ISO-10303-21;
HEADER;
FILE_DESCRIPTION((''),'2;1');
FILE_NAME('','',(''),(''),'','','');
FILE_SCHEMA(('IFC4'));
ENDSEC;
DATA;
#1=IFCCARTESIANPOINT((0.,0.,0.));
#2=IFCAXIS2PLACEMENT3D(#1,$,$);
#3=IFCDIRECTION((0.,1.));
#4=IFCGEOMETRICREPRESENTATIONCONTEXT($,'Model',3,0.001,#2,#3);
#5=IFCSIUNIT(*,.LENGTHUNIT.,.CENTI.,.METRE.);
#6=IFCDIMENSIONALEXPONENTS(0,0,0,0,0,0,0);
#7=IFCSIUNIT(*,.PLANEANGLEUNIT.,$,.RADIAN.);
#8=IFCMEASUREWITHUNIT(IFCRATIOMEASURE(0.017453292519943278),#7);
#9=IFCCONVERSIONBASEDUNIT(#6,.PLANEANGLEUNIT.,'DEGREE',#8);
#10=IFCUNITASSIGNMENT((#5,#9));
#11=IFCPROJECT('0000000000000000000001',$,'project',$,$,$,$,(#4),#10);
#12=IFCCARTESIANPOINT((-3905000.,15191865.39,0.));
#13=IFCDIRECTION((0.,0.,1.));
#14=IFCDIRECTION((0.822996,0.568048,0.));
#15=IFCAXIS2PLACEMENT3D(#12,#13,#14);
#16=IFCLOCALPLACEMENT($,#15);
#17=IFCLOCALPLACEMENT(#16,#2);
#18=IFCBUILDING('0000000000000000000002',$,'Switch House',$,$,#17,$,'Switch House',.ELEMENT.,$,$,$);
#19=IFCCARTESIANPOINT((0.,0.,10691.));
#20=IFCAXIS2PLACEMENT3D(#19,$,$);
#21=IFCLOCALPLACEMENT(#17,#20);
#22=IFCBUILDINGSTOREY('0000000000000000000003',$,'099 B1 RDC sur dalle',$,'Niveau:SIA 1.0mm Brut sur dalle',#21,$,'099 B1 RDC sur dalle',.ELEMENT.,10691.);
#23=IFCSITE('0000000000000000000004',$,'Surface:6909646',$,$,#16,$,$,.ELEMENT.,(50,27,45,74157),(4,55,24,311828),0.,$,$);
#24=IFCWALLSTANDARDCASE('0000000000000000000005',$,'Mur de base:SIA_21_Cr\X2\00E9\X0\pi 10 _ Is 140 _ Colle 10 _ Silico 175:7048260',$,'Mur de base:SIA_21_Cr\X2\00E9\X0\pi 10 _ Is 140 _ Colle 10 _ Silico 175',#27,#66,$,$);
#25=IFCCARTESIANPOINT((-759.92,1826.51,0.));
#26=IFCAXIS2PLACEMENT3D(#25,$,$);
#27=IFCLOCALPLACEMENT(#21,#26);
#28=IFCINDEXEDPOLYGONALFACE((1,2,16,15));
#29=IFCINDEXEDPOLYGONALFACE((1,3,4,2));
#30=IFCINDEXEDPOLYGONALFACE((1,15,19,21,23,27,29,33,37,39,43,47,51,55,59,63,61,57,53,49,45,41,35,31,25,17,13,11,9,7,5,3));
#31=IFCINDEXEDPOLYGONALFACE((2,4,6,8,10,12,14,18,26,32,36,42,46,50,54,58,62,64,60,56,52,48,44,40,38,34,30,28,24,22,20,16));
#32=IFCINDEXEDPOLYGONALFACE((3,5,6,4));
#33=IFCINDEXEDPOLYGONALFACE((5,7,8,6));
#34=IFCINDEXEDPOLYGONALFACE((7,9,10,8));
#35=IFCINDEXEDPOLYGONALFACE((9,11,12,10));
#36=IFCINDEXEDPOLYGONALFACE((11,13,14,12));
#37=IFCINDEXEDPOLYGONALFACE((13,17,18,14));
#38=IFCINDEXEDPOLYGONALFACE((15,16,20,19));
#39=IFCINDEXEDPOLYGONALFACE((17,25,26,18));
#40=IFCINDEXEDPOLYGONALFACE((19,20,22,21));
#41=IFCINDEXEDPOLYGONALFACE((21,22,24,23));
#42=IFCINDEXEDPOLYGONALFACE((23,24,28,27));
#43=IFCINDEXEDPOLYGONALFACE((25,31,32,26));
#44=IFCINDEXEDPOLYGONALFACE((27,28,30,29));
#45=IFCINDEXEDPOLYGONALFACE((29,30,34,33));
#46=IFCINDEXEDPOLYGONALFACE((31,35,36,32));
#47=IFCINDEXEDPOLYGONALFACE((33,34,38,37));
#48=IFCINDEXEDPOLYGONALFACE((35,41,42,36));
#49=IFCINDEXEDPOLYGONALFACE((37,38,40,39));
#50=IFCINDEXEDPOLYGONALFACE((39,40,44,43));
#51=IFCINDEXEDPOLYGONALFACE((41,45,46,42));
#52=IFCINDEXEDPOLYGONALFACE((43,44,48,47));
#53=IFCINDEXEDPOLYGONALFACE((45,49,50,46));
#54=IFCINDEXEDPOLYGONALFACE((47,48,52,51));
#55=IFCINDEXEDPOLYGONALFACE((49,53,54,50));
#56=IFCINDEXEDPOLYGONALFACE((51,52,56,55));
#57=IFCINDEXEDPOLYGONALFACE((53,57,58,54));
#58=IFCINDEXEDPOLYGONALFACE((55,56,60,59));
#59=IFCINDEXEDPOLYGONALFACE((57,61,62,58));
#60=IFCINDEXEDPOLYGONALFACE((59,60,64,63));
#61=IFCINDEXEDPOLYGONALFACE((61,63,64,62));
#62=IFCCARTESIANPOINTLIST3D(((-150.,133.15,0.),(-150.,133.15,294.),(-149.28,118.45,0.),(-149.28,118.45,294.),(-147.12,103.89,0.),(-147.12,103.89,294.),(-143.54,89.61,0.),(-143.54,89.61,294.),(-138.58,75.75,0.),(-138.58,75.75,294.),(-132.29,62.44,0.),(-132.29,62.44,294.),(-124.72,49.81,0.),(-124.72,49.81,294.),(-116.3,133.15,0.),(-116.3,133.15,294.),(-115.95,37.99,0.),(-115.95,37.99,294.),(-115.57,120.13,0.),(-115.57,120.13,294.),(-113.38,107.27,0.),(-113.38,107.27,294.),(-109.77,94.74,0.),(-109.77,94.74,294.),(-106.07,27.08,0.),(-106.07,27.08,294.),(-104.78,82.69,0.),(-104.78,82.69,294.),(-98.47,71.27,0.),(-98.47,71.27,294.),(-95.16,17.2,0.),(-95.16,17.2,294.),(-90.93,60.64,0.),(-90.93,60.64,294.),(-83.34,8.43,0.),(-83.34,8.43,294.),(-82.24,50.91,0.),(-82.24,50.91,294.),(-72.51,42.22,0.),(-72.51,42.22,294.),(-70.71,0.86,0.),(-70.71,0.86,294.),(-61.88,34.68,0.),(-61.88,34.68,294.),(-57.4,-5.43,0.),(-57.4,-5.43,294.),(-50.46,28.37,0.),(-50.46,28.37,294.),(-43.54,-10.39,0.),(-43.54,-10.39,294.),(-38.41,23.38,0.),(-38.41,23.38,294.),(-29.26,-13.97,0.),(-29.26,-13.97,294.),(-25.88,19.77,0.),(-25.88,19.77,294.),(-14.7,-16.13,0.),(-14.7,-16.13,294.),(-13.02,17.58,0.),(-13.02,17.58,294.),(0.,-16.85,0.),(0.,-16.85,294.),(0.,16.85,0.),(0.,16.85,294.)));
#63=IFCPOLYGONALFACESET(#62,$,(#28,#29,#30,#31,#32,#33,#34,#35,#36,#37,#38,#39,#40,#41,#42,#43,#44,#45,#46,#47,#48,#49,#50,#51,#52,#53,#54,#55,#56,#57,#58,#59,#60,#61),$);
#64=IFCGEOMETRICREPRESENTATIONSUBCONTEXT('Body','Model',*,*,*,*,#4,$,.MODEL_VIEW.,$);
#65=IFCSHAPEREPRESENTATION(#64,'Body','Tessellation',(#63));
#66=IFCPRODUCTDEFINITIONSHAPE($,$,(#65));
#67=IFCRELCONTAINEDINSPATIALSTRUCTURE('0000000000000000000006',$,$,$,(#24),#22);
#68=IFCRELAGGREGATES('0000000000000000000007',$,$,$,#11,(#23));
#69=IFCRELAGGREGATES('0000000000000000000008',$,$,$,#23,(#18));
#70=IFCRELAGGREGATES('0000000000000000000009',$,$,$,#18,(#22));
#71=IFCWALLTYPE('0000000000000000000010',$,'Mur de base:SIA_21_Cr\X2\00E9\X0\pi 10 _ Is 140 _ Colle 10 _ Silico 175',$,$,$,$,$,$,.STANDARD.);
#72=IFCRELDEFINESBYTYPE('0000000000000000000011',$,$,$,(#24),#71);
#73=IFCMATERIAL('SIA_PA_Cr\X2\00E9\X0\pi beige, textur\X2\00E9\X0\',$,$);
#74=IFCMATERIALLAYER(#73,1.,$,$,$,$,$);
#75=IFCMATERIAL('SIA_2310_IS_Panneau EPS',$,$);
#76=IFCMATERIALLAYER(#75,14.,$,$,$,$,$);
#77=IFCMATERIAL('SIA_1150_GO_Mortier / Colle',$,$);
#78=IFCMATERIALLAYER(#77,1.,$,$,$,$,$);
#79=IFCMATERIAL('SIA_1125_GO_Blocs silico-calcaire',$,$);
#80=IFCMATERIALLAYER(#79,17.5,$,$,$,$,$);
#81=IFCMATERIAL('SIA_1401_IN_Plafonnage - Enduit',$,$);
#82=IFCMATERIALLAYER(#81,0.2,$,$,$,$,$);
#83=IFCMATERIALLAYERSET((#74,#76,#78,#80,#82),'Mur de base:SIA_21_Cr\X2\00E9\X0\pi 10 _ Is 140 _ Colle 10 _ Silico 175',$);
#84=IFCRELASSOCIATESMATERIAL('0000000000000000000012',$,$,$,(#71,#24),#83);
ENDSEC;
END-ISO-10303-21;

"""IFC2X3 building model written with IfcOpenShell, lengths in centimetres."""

from ifc_helpers import new_model, entity, si_unit, converted_unit, direction, frame, frame_2d, origin, place, context, subcontext, project, spatial, polyline, circle_curve, parameter, trimmed, segment, composite_curve, outline, extrude, clip, halfspace, material, layer, layer_set, layer_usage, type_object, element, save


model = new_model("IFC2X3")

# Units and contexts
model_context = context("Model", 3, precision=0.001, world=origin(), true_north=direction((0.0, 1.0)))
body_context = subcontext(model_context, "Body", "Model", "MODEL_VIEW")
ifc_project = project(units=[si_unit("LENGTHUNIT", "METRE", prefix="CENTI"), converted_unit("PLANEANGLEUNIT", "DEGREE", entity("IfcRatioMeasure", 0.017453292519943278), si_unit("PLANEANGLEUNIT", "RADIAN"), dimensions=[0, 0, 0, 0, 0, 0, 0])], contexts=[model_context])

# Site, building, storey
site_placement = place(None, frame((-3905000.0, 15191865.39, 0.0), z_axis=(0.0, 0.0, 1.0), x_axis=(0.822996, 0.568048, 0.0)))
site = spatial("IfcSite", under=ifc_project, at=site_placement, Name="Surface:6909646", CompositionType="ELEMENT", RefLatitude=(50, 27, 45, 74157), RefLongitude=(4, 55, 24, 311828), RefElevation=0.0)
building_placement = place(site_placement, origin())
building = spatial("IfcBuilding", under=site, at=building_placement, Name="Switch House", LongName="Switch House", CompositionType="ELEMENT")
storey_placement = place(building_placement, frame((0.0, 0.0, 10691.0)))
storey = spatial("IfcBuildingStorey", under=building, at=storey_placement, Name="099 B1 RDC sur dalle", ObjectType="Niveau:SIA 1.0mm Brut sur dalle", LongName="099 B1 RDC sur dalle", CompositionType="ELEMENT", Elevation=10691.0)

# Wall
ifc_material_1 = material(Name="SIA_PA_Crépi beige, texturé")
ifc_layer_1 = layer(ifc_material_1, 1.0)
ifc_material_2 = material(Name="SIA_2310_IS_Panneau EPS")
ifc_layer_2 = layer(ifc_material_2, 14.0)
ifc_material_3 = material(Name="SIA_1150_GO_Mortier / Colle")
ifc_layer_3 = layer(ifc_material_3, 1.0)
ifc_material_4 = material(Name="SIA_1125_GO_Blocs silico-calcaire")
ifc_layer_4 = layer(ifc_material_4, 17.5)
ifc_material_5 = material(Name="SIA_1401_IN_Plafonnage - Enduit")
ifc_layer_5 = layer(ifc_material_5, 0.2)
ifc_layer_set_1 = layer_set([ifc_layer_1, ifc_layer_2, ifc_layer_3, ifc_layer_4, ifc_layer_5], Name="Mur de base:SIA_21_Crépi 10 _ Is 140 _ Colle 10 _ Silico 175")
wall_type = type_object("IfcWallType", Name="Mur de base:SIA_21_Crépi 10 _ Is 140 _ Colle 10 _ Silico 175", PredefinedType="STANDARD", material=ifc_layer_set_1)
ifc_layer_usage_1 = layer_usage(ifc_layer_set_1, "AXIS2", "POSITIVE", -16.85)
wall_1_placement = place(storey_placement, frame((-759.92, 1826.51, 0.0)))
element("IfcWallStandardCase", 1, at=wall_1_placement, inside=storey, type_object=wall_type, material=ifc_layer_usage_1, Name="Mur de base:SIA_21_Crépi 10 _ Is 140 _ Colle 10 _ Silico 175:7048260", ObjectType="Mur de base:SIA_21_Crépi 10 _ Is 140 _ Colle 10 _ Silico 175", context=body_context, shape_type="Clipping", body=[
    clip(extrude(outline(composite_curve([segment(trimmed(circle_curve(frame_2d((0.0, 133.15), x_axis=(1.0, 0.0)), 150.0), [parameter(180.0)], [parameter(270.0)], True, "PARAMETER"), True, "CONTINUOUS"), segment(polyline([(0.0, -16.85), (0.0, 16.85)]), True, "CONTINUOUS"), segment(trimmed(circle_curve(frame_2d((0.0, 133.15), x_axis=(1.0, 0.0)), 116.3), [parameter(180.0)], [parameter(270.0)], True, "PARAMETER"), False, "CONTINUOUS"), segment(polyline([(-116.3, 133.15), (-150.0, 133.15)]), True, "CONTINUOUS")], self_intersect=False)), origin(), (0.0, 0.0, 1.0), 294.0), halfspace(frame((-150.0, 133.15, 294.0), z_axis=(0.0, 0.0, -1.0), x_axis=(0.0, -1.0, 0.0)), True)),
])

save(model, "model.ifc")
